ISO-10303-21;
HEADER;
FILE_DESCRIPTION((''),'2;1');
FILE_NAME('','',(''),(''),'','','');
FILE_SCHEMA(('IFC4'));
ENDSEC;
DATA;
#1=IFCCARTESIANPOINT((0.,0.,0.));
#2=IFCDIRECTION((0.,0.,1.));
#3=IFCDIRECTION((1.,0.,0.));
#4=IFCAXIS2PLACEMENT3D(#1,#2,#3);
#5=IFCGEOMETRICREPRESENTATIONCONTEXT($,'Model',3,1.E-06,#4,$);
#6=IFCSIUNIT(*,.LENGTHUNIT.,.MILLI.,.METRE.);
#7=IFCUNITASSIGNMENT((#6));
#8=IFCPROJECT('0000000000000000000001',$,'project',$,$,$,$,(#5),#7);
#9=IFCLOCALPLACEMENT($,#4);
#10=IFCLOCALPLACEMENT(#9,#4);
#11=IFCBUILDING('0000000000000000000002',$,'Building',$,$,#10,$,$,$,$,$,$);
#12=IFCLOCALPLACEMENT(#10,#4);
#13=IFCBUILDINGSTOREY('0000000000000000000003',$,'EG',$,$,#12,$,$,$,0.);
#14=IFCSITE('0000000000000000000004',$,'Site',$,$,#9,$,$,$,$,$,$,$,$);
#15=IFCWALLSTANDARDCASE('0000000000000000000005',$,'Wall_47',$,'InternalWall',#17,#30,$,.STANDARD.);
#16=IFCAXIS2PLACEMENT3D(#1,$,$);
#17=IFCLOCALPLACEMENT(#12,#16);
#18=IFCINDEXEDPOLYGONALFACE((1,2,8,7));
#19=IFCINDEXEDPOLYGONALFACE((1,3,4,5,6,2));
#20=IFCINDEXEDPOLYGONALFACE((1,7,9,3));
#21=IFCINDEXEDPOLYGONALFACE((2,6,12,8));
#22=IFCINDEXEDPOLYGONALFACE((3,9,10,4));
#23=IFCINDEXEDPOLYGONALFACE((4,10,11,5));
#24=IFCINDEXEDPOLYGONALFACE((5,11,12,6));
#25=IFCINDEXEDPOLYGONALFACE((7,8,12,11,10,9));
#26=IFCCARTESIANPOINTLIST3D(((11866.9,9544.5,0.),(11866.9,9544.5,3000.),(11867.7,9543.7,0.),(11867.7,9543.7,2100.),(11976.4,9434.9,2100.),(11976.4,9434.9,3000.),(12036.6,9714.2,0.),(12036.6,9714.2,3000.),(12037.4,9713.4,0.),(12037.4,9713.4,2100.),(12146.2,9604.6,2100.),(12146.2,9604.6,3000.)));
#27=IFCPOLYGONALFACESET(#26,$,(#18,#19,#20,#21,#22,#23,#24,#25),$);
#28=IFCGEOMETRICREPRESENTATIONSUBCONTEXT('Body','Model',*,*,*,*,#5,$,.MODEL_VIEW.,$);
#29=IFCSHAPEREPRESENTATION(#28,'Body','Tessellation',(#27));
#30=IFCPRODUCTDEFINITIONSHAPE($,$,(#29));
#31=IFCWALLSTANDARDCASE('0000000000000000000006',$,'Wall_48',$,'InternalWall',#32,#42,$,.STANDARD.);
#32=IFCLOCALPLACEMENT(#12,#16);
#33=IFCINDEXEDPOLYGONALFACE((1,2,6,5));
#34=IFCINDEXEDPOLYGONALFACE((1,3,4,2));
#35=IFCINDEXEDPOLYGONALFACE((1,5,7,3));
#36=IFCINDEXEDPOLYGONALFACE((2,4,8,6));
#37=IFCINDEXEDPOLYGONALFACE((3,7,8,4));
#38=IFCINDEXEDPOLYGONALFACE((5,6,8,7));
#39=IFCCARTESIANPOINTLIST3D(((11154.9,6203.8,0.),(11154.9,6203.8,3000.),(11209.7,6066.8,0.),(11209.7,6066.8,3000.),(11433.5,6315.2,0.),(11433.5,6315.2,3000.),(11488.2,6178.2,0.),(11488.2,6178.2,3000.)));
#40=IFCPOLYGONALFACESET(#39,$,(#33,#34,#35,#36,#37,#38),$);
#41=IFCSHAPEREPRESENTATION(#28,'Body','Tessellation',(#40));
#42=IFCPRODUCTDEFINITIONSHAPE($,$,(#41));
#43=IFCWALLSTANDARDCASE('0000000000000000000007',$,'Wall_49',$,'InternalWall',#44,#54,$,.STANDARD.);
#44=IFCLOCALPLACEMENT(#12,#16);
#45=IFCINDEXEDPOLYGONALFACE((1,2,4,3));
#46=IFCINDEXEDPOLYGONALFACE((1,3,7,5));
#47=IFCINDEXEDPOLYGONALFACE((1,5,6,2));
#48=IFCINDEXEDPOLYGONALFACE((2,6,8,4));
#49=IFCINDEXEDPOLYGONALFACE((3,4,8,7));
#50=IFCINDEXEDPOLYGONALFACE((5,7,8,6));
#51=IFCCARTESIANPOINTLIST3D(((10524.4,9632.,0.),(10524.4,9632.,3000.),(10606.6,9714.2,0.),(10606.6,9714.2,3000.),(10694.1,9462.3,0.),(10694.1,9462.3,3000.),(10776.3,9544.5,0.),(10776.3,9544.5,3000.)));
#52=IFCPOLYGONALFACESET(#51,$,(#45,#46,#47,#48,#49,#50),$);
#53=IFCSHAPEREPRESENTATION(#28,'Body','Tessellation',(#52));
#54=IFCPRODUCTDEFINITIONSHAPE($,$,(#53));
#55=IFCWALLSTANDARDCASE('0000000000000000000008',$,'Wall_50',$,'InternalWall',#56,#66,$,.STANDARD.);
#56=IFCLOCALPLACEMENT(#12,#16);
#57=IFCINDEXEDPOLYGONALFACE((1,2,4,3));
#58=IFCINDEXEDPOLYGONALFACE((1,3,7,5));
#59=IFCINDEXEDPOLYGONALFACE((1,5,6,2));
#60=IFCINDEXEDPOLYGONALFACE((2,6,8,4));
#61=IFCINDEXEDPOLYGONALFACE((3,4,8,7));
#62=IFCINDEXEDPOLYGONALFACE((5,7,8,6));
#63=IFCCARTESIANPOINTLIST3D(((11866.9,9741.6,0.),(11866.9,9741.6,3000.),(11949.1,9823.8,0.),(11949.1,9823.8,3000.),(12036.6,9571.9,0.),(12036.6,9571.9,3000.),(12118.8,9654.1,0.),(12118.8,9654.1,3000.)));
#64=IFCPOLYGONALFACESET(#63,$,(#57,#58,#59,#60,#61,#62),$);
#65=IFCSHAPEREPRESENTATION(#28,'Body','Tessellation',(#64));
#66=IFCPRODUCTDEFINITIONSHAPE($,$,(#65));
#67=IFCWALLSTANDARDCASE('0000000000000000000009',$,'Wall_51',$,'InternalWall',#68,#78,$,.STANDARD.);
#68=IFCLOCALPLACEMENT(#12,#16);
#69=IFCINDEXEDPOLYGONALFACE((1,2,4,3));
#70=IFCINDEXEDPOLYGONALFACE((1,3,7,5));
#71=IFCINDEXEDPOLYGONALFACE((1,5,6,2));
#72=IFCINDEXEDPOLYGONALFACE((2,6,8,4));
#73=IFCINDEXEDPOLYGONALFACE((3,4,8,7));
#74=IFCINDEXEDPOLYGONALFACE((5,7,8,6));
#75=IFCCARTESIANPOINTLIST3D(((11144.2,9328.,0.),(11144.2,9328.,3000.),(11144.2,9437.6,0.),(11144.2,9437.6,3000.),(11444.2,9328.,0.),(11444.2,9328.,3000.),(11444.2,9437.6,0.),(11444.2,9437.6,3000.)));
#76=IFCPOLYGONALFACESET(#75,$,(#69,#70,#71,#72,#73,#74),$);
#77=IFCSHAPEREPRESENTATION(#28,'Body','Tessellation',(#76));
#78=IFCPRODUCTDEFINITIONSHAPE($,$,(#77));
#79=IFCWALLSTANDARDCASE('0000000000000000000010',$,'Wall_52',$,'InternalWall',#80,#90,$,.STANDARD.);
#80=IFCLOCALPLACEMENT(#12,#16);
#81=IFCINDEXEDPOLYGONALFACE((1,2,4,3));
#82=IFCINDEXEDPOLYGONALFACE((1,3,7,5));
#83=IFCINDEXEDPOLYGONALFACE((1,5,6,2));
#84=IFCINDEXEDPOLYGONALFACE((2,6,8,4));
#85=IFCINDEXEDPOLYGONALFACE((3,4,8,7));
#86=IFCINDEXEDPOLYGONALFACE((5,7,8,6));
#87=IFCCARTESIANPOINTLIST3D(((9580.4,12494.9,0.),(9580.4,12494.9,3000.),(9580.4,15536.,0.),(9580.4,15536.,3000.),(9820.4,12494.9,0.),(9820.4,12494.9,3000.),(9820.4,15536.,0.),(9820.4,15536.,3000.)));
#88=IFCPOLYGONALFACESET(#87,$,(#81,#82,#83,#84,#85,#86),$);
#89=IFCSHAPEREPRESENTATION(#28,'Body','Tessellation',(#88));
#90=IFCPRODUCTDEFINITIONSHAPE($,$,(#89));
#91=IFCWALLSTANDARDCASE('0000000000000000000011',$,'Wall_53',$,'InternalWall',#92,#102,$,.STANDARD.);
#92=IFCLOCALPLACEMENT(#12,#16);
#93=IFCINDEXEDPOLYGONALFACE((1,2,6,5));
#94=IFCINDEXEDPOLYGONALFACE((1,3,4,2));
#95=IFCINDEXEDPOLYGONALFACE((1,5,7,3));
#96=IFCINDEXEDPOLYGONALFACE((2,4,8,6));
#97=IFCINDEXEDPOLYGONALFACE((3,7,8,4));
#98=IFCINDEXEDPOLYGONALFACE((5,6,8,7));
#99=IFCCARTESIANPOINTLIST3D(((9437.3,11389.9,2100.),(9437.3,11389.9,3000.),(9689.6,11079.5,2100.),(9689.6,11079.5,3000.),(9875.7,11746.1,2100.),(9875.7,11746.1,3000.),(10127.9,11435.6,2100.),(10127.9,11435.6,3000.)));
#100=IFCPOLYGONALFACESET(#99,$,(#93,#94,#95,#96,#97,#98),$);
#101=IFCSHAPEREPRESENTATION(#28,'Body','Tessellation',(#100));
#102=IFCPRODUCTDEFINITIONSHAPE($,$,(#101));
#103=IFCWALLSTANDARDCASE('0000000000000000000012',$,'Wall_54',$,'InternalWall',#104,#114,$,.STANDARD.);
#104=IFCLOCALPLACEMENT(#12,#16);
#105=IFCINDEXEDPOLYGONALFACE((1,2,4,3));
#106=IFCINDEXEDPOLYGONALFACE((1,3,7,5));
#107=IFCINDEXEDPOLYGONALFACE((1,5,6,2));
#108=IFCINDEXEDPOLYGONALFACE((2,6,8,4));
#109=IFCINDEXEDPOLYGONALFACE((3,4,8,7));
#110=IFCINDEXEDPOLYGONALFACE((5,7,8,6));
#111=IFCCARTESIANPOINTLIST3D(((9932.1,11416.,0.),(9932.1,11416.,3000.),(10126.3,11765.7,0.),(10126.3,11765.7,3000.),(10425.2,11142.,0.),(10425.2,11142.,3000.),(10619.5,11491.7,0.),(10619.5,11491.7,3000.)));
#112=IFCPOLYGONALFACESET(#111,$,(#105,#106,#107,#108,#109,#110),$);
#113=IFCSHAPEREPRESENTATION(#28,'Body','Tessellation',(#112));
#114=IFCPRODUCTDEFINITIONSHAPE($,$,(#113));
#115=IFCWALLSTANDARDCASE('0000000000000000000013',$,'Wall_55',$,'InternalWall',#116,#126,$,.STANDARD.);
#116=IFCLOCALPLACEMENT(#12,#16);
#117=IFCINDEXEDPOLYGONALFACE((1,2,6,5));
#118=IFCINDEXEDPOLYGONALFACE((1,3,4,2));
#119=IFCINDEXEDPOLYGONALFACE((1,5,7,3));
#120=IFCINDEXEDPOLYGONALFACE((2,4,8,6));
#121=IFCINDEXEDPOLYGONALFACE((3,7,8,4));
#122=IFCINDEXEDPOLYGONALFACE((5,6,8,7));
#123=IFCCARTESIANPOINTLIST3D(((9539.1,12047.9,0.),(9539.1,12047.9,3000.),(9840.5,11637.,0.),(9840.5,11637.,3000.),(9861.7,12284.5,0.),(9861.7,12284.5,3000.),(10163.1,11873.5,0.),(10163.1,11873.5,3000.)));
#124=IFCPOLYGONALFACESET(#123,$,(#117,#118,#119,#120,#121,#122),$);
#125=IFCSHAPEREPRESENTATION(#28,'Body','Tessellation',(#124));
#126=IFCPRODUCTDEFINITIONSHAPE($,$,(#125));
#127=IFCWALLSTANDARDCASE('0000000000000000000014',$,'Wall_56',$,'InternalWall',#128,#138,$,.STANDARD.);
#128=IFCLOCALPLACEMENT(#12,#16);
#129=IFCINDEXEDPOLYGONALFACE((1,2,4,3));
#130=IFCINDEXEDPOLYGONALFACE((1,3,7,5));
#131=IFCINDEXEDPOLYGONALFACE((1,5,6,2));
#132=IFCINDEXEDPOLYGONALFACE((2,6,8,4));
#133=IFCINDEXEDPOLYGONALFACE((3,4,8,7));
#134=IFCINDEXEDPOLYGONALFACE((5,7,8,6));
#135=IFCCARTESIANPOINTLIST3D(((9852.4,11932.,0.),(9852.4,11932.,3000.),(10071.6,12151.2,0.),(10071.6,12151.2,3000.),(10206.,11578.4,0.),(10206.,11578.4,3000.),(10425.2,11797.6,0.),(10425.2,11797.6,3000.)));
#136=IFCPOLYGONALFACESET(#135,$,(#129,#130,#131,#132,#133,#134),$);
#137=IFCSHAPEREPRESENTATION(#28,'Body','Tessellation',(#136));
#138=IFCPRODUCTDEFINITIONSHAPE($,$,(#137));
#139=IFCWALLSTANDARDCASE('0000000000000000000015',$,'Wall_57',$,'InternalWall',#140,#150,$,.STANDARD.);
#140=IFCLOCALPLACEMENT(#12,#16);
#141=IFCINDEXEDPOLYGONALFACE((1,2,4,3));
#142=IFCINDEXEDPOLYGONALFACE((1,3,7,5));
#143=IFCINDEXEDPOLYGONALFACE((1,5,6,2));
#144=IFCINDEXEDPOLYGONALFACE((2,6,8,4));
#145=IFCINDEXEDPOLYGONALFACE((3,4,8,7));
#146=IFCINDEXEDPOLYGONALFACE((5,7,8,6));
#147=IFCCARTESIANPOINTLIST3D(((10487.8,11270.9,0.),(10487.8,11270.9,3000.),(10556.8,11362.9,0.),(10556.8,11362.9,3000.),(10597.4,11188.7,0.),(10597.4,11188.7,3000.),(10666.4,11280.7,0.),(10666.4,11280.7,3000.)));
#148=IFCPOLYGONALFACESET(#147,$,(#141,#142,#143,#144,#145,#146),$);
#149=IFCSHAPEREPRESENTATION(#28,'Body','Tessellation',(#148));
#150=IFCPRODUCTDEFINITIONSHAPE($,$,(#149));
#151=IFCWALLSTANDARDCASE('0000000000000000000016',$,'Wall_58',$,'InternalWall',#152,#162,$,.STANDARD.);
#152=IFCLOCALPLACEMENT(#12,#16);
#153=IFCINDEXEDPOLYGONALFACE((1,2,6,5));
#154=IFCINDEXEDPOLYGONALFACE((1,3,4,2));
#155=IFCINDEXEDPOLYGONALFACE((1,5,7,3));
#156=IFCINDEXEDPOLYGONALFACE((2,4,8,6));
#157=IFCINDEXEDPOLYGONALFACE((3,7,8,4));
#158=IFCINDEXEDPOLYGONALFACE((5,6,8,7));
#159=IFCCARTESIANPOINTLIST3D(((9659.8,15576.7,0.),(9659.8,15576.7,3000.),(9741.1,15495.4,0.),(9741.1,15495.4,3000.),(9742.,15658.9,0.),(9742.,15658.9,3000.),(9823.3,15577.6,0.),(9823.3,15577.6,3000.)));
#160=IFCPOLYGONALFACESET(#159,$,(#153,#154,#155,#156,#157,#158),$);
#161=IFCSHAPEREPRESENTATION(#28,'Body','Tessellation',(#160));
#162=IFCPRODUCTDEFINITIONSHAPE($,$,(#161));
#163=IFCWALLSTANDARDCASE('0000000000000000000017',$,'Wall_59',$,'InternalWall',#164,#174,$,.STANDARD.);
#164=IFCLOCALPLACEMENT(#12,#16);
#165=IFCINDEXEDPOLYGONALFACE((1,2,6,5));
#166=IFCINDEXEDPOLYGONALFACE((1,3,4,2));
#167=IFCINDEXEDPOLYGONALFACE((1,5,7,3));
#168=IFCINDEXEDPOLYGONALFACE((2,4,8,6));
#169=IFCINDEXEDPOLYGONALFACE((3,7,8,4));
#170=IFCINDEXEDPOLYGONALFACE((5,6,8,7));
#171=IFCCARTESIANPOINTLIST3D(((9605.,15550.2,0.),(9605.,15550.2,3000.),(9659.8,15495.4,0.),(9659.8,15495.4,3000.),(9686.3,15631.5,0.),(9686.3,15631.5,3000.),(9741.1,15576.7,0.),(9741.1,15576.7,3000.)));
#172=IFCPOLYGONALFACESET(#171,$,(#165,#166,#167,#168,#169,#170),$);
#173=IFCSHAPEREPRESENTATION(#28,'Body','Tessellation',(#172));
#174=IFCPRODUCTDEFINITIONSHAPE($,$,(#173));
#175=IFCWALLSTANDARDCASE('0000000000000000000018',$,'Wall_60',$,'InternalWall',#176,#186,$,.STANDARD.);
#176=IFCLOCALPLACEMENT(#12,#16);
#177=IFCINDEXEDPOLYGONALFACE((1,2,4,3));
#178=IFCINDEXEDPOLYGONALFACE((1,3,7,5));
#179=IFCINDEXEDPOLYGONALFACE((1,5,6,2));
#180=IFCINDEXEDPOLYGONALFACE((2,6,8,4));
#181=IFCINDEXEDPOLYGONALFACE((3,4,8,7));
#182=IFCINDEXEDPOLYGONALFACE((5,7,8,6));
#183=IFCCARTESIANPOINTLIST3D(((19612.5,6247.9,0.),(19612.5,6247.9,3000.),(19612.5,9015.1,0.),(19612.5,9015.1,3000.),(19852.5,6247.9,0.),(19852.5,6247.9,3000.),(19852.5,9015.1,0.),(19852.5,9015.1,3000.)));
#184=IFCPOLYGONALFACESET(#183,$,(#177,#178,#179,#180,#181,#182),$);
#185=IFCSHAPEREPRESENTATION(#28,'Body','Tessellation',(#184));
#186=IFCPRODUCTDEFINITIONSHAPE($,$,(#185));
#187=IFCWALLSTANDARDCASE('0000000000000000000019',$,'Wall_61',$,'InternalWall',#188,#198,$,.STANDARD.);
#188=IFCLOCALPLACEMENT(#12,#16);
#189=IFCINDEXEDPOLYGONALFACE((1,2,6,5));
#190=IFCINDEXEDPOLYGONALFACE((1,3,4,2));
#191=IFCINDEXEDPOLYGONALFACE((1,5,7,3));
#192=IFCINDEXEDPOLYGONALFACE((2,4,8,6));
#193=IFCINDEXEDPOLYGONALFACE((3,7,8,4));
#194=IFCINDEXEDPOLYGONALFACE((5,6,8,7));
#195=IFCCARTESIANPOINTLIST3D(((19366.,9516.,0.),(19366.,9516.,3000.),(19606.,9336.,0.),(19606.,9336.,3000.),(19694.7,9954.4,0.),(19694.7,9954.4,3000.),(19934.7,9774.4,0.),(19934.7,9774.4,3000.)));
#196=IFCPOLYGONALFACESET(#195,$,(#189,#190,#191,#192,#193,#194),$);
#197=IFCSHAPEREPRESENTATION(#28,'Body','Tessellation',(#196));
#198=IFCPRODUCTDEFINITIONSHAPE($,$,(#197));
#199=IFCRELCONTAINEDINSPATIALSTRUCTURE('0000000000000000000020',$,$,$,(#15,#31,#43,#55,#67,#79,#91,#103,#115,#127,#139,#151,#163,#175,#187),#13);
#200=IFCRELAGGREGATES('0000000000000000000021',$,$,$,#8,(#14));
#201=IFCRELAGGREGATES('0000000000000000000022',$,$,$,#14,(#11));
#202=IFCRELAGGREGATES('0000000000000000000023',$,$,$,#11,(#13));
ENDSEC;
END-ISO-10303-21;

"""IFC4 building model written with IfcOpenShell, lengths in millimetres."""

from ifc_helpers import new_model, si_unit, frame, origin_with_axes, place, context, subcontext, project, spatial, rectangle, extrude, element, save


model = new_model("IFC4")

# Units and contexts
model_context = context("Model", 3, precision=1e-06, world=origin_with_axes())
body_context = subcontext(model_context, "Body", "Model", "MODEL_VIEW")
ifc_project = project(units=[si_unit("LENGTHUNIT", "METRE", prefix="MILLI")], contexts=[model_context])

# Site, building, storey
site_placement = place(None, origin_with_axes())
site = spatial("IfcSite", under=ifc_project, at=site_placement, Name="Site")
building_placement = place(site_placement, origin_with_axes())
building = spatial("IfcBuilding", under=site, at=building_placement, Name="Building")
storey_placement = place(building_placement, origin_with_axes())
storey = spatial("IfcBuildingStorey", under=building, at=storey_placement, Name="EG", Elevation=0.0)

# Wall, opening
wall_1_placement = place(storey_placement, origin_with_axes())
wall_1 = element("IfcWallStandardCase", 1, at=wall_1_placement, inside=storey, Name="Wall_47", ObjectType="InternalWall", PredefinedType="STANDARD", context=body_context, shape_type="SweptSolid", body=[
    extrude(rectangle(XDim=155.0, YDim=240.0), frame((12006.5, 9574.6, 0.0), z_axis=(0.0, 0.0, 1.0), x_axis=(0.707107, -0.707107, 0.0)), (0.0, 0.0, 1.0), 3000.0),
])
opening_1_placement = place(wall_1_placement, origin_with_axes())
element("IfcOpeningElement", 2, at=opening_1_placement, inside=storey, cuts=wall_1, context=body_context, shape_type="SweptSolid", body=[
    extrude(rectangle(XDim=1292.5, YDim=240.0), frame((12409.5, 9171.5, 0.0), z_axis=(0.0, 0.0, 1.0), x_axis=(0.707107, -0.707107, 0.0)), (0.0, 0.0, 1.0), 2100.0),
])

# Walls
wall_2_placement = place(storey_placement, origin_with_axes())
element("IfcWallStandardCase", 3, at=wall_2_placement, inside=storey, Name="Wall_48", ObjectType="InternalWall", PredefinedType="STANDARD", context=body_context, shape_type="SweptSolid", body=[
    extrude(rectangle(XDim=147.5, YDim=300.0), frame((11321.6, 6191.0, 0.0), z_axis=(0.0, 0.0, 1.0), x_axis=(-0.371391, 0.928477, 0.0)), (0.0, 0.0, 1.0), 3000.0),
])
wall_3_placement = place(storey_placement, origin_with_axes())
element("IfcWallStandardCase", 4, at=wall_3_placement, inside=storey, Name="Wall_49", ObjectType="InternalWall", PredefinedType="STANDARD", context=body_context, shape_type="SweptSolid", body=[
    extrude(rectangle(XDim=116.2, YDim=240.0), frame((10650.3, 9588.3, 0.0), z_axis=(0.0, 0.0, 1.0), x_axis=(-0.707107, -0.707107, 0.0)), (0.0, 0.0, 1.0), 3000.0),
])
wall_4_placement = place(storey_placement, origin_with_axes())
element("IfcWallStandardCase", 5, at=wall_4_placement, inside=storey, Name="Wall_50", ObjectType="InternalWall", PredefinedType="STANDARD", context=body_context, shape_type="SweptSolid", body=[
    extrude(rectangle(XDim=116.2, YDim=240.0), frame((11992.8, 9697.9, 0.0), z_axis=(0.0, 0.0, 1.0), x_axis=(0.707107, 0.707107, 0.0)), (0.0, 0.0, 1.0), 3000.0),
])
wall_5_placement = place(storey_placement, origin_with_axes())
element("IfcWallStandardCase", 6, at=wall_5_placement, inside=storey, Name="Wall_51", ObjectType="InternalWall", PredefinedType="STANDARD", context=body_context, shape_type="SweptSolid", body=[
    extrude(rectangle(XDim=109.6, YDim=300.0), frame((11294.2, 9382.8, 0.0), z_axis=(0.0, 0.0, 1.0), x_axis=(0.0, 1.0, 0.0)), (0.0, 0.0, 1.0), 3000.0),
])
wall_6_placement = place(storey_placement, origin_with_axes())
element("IfcWallStandardCase", 7, at=wall_6_placement, inside=storey, Name="Wall_52", ObjectType="InternalWall", PredefinedType="STANDARD", context=body_context, shape_type="SweptSolid", body=[
    extrude(rectangle(XDim=3041.1, YDim=240.0), frame((9700.4, 14015.5, 0.0), z_axis=(0.0, 0.0, 1.0), x_axis=(0.0, 1.0, 0.0)), (0.0, 0.0, 1.0), 3000.0),
])

# Wall, opening
wall_7_placement = place(storey_placement, origin_with_axes())
wall_7 = element("IfcWallStandardCase", 8, at=wall_7_placement, inside=storey, Name="Wall_53", ObjectType="InternalWall", PredefinedType="STANDARD", context=body_context, shape_type="SweptSolid", body=[
    extrude(rectangle(XDim=564.8, YDim=400.0), frame((9782.6, 11412.8, 0.0), z_axis=(0.0, 0.0, 1.0), x_axis=(-0.776114, -0.630593, 0.0)), (0.0, 0.0, 1.0), 3000.0),
])
opening_2_placement = place(wall_7_placement, origin_with_axes())
element("IfcOpeningElement", 9, at=opening_2_placement, inside=storey, cuts=wall_7, context=body_context, shape_type="SweptSolid", body=[
    extrude(rectangle(XDim=1323.7, YDim=400.0), frame((9554.3, 11227.3, 0.0), z_axis=(0.0, 0.0, 1.0), x_axis=(-0.776114, -0.630593, 0.0)), (0.0, 0.0, 1.0), 2100.0),
])

# Walls
wall_8_placement = place(storey_placement, origin_with_axes())
element("IfcWallStandardCase", 10, at=wall_8_placement, inside=storey, Name="Wall_54", ObjectType="InternalWall", PredefinedType="STANDARD", context=body_context, shape_type="SweptSolid", body=[
    extrude(rectangle(XDim=564.1, YDim=400.0), frame((10275.8, 11453.9, 0.0), z_axis=(0.0, 0.0, 1.0), x_axis=(0.874157, -0.485643, 0.0)), (0.0, 0.0, 1.0), 3000.0),
])
wall_9_placement = place(storey_placement, origin_with_axes())
element("IfcWallStandardCase", 11, at=wall_9_placement, inside=storey, Name="Wall_55", ObjectType="InternalWall", PredefinedType="STANDARD", context=body_context, shape_type="SweptSolid", body=[
    extrude(rectangle(XDim=509.6, YDim=400.0), frame((9851.1, 11960.7, 0.0), z_axis=(0.0, 0.0, 1.0), x_axis=(-0.591364, 0.806405, 0.0)), (0.0, 0.0, 1.0), 3000.0),
])
wall_10_placement = place(storey_placement, origin_with_axes())
element("IfcWallStandardCase", 12, at=wall_10_placement, inside=storey, Name="Wall_56", ObjectType="InternalWall", PredefinedType="STANDARD", context=body_context, shape_type="SweptSolid", body=[
    extrude(rectangle(XDim=310.0, YDim=500.0), frame((10138.8, 11864.8, 0.0), z_axis=(0.0, 0.0, 1.0), x_axis=(0.707107, 0.707107, 0.0)), (0.0, 0.0, 1.0), 3000.0),
])
wall_11_placement = place(storey_placement, origin_with_axes())
element("IfcWallStandardCase", 13, at=wall_11_placement, inside=storey, Name="Wall_57", ObjectType="InternalWall", PredefinedType="STANDARD", context=body_context, shape_type="SweptSolid", body=[
    extrude(rectangle(XDim=137.0, YDim=115.0), frame((10577.1, 11275.8, 0.0), z_axis=(0.0, 0.0, 1.0), x_axis=(0.8, -0.6, 0.0)), (0.0, 0.0, 1.0), 3000.0),
])
wall_12_placement = place(storey_placement, origin_with_axes())
element("IfcWallStandardCase", 14, at=wall_12_placement, inside=storey, Name="Wall_58", ObjectType="InternalWall", PredefinedType="STANDARD", context=body_context, shape_type="SweptSolid", body=[
    extrude(rectangle(XDim=116.2, YDim=115.0), frame((9741.5, 15577.1, 0.0), z_axis=(0.0, 0.0, 1.0), x_axis=(0.707107, 0.707107, 0.0)), (0.0, 0.0, 1.0), 3000.0),
])
wall_13_placement = place(storey_placement, origin_with_axes())
element("IfcWallStandardCase", 15, at=wall_13_placement, inside=storey, Name="Wall_59", ObjectType="InternalWall", PredefinedType="STANDARD", context=body_context, shape_type="SweptSolid", body=[
    extrude(rectangle(XDim=77.5, YDim=115.0), frame((9673.0, 15563.4, 0.0), z_axis=(0.0, 0.0, 1.0), x_axis=(-0.707107, 0.707107, 0.0)), (0.0, 0.0, 1.0), 3000.0),
])
wall_14_placement = place(storey_placement, origin_with_axes())
element("IfcWallStandardCase", 16, at=wall_14_placement, inside=storey, Name="Wall_60", ObjectType="InternalWall", PredefinedType="STANDARD", context=body_context, shape_type="SweptSolid", body=[
    extrude(rectangle(XDim=2767.1, YDim=240.0), frame((19732.5, 7631.5, 0.0), z_axis=(0.0, 0.0, 1.0), x_axis=(0.0, -1.0, 0.0)), (0.0, 0.0, 1.0), 3000.0),
])
wall_15_placement = place(storey_placement, origin_with_axes())
element("IfcWallStandardCase", 17, at=wall_15_placement, inside=storey, Name="Wall_61", ObjectType="InternalWall", PredefinedType="STANDARD", context=body_context, shape_type="SweptSolid", body=[
    extrude(rectangle(XDim=547.9, YDim=300.0), frame((19650.3, 9645.2, 0.0), z_axis=(0.0, 0.0, 1.0), x_axis=(0.6, 0.8, 0.0)), (0.0, 0.0, 1.0), 3000.0),
])

save(model, "model.ifc")
